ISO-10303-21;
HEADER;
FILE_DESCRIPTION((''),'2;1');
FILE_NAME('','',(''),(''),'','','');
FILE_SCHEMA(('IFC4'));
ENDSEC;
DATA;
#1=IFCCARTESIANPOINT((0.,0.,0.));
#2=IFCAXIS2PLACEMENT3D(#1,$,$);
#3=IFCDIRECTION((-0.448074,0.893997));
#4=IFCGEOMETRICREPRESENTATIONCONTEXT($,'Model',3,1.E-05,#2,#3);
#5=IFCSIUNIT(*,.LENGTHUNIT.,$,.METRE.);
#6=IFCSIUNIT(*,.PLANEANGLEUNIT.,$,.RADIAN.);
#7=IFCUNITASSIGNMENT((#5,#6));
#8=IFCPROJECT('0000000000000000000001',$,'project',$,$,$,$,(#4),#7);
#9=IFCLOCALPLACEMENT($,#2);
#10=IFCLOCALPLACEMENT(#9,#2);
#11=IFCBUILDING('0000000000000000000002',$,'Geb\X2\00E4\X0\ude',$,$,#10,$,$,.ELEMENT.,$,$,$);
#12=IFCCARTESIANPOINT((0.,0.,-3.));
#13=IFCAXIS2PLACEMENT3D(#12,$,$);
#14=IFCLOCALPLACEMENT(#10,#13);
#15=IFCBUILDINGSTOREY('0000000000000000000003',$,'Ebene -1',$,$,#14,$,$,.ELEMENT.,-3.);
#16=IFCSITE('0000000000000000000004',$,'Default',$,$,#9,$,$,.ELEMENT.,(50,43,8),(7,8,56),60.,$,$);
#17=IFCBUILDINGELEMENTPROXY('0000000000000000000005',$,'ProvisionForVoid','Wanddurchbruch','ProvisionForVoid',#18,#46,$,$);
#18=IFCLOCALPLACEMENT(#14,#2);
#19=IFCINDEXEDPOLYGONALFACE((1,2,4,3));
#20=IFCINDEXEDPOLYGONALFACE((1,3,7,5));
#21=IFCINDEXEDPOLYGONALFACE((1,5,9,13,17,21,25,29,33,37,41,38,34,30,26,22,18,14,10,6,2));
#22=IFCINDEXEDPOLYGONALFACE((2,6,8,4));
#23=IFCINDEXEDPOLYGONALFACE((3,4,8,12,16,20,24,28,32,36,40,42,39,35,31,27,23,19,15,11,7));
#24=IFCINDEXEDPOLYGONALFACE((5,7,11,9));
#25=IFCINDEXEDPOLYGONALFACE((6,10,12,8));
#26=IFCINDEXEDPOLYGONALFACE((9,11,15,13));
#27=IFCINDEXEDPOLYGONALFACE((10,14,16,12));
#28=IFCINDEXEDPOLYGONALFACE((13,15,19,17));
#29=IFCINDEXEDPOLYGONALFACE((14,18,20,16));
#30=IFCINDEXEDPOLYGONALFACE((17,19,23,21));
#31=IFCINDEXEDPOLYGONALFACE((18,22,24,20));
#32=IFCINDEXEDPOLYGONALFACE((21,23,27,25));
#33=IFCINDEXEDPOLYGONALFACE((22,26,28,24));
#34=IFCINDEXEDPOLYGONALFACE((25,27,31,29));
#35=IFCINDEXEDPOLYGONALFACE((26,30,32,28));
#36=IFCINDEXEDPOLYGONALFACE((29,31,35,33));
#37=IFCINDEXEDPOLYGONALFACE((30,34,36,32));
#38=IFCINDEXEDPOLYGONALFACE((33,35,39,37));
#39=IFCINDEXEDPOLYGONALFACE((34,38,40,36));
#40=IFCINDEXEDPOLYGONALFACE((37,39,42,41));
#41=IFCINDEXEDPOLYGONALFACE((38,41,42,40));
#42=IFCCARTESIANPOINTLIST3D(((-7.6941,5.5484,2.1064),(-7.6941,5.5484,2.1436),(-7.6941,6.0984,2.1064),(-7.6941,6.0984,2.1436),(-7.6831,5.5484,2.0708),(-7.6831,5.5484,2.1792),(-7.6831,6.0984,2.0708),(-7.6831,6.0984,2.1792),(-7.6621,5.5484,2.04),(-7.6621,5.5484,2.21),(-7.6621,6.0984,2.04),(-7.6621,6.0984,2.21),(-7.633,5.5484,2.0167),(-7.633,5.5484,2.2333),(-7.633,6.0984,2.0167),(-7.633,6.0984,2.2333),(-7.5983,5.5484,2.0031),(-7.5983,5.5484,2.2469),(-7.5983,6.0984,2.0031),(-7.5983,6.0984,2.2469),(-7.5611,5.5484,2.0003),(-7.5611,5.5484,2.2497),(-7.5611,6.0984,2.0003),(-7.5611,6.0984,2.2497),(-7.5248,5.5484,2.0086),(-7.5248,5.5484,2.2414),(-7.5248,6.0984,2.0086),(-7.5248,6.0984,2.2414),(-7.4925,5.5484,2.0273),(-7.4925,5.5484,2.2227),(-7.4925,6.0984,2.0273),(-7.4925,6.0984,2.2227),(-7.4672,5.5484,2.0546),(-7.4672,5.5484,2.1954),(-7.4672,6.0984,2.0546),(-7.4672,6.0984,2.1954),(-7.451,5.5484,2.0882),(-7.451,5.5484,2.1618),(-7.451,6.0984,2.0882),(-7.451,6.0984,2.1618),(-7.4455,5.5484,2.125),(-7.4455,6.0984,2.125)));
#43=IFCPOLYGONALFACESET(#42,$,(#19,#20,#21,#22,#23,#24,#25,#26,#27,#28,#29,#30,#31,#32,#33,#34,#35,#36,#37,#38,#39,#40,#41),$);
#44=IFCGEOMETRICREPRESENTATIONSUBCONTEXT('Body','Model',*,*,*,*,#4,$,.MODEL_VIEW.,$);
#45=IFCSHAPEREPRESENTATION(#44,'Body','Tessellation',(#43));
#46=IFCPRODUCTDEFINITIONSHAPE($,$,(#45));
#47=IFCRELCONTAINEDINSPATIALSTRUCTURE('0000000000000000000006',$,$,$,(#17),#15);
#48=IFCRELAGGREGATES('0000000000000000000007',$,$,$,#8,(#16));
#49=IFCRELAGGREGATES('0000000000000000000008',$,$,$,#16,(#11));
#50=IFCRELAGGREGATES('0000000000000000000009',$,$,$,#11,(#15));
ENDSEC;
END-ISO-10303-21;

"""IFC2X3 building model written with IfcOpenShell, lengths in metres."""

from ifc_helpers import new_model, si_unit, direction, frame, frame_2d, origin, place, context, subcontext, project, spatial, circle, extrude, element, save


model = new_model("IFC2X3")

# Units and contexts
model_context = context("Model", 3, precision=1e-05, world=origin(), true_north=direction((-0.448074, 0.893997)))
body_context = subcontext(model_context, "Body", "Model", "MODEL_VIEW")
ifc_project = project(units=[si_unit("LENGTHUNIT", "METRE"), si_unit("PLANEANGLEUNIT", "RADIAN")], contexts=[model_context])

# Site, building, storey
site_placement = place(None, origin())
site = spatial("IfcSite", under=ifc_project, at=site_placement, Name="Default", CompositionType="ELEMENT", RefLatitude=(50, 43, 8), RefLongitude=(7, 8, 56), RefElevation=60.0)
building_placement = place(site_placement, origin())
building = spatial("IfcBuilding", under=site, at=building_placement, Name="Gebäude", CompositionType="ELEMENT")
storey_placement = place(building_placement, frame((0.0, 0.0, -3.0)))
storey = spatial("IfcBuildingStorey", under=building, at=storey_placement, Name="Ebene -1", CompositionType="ELEMENT", Elevation=-3.0)

# Building element proxy
proxy_placement = place(storey_placement, origin())
element("IfcBuildingElementProxy", 1, at=proxy_placement, inside=storey, Name="ProvisionForVoid", Description="Wanddurchbruch", ObjectType="ProvisionForVoid", context=body_context, shape_type="SweptSolid", body=[
    extrude(circle(Radius=0.125, at=frame_2d((0.0, 0.0), x_axis=(1.0, 0.0))), frame((-7.5705, 6.0984, 2.125), z_axis=(0.0, -1.0, 0.0), x_axis=(1.0, 0.0, 0.0)), (0.0, 0.0, 1.0), 0.55),
])

save(model, "model.ifc")
